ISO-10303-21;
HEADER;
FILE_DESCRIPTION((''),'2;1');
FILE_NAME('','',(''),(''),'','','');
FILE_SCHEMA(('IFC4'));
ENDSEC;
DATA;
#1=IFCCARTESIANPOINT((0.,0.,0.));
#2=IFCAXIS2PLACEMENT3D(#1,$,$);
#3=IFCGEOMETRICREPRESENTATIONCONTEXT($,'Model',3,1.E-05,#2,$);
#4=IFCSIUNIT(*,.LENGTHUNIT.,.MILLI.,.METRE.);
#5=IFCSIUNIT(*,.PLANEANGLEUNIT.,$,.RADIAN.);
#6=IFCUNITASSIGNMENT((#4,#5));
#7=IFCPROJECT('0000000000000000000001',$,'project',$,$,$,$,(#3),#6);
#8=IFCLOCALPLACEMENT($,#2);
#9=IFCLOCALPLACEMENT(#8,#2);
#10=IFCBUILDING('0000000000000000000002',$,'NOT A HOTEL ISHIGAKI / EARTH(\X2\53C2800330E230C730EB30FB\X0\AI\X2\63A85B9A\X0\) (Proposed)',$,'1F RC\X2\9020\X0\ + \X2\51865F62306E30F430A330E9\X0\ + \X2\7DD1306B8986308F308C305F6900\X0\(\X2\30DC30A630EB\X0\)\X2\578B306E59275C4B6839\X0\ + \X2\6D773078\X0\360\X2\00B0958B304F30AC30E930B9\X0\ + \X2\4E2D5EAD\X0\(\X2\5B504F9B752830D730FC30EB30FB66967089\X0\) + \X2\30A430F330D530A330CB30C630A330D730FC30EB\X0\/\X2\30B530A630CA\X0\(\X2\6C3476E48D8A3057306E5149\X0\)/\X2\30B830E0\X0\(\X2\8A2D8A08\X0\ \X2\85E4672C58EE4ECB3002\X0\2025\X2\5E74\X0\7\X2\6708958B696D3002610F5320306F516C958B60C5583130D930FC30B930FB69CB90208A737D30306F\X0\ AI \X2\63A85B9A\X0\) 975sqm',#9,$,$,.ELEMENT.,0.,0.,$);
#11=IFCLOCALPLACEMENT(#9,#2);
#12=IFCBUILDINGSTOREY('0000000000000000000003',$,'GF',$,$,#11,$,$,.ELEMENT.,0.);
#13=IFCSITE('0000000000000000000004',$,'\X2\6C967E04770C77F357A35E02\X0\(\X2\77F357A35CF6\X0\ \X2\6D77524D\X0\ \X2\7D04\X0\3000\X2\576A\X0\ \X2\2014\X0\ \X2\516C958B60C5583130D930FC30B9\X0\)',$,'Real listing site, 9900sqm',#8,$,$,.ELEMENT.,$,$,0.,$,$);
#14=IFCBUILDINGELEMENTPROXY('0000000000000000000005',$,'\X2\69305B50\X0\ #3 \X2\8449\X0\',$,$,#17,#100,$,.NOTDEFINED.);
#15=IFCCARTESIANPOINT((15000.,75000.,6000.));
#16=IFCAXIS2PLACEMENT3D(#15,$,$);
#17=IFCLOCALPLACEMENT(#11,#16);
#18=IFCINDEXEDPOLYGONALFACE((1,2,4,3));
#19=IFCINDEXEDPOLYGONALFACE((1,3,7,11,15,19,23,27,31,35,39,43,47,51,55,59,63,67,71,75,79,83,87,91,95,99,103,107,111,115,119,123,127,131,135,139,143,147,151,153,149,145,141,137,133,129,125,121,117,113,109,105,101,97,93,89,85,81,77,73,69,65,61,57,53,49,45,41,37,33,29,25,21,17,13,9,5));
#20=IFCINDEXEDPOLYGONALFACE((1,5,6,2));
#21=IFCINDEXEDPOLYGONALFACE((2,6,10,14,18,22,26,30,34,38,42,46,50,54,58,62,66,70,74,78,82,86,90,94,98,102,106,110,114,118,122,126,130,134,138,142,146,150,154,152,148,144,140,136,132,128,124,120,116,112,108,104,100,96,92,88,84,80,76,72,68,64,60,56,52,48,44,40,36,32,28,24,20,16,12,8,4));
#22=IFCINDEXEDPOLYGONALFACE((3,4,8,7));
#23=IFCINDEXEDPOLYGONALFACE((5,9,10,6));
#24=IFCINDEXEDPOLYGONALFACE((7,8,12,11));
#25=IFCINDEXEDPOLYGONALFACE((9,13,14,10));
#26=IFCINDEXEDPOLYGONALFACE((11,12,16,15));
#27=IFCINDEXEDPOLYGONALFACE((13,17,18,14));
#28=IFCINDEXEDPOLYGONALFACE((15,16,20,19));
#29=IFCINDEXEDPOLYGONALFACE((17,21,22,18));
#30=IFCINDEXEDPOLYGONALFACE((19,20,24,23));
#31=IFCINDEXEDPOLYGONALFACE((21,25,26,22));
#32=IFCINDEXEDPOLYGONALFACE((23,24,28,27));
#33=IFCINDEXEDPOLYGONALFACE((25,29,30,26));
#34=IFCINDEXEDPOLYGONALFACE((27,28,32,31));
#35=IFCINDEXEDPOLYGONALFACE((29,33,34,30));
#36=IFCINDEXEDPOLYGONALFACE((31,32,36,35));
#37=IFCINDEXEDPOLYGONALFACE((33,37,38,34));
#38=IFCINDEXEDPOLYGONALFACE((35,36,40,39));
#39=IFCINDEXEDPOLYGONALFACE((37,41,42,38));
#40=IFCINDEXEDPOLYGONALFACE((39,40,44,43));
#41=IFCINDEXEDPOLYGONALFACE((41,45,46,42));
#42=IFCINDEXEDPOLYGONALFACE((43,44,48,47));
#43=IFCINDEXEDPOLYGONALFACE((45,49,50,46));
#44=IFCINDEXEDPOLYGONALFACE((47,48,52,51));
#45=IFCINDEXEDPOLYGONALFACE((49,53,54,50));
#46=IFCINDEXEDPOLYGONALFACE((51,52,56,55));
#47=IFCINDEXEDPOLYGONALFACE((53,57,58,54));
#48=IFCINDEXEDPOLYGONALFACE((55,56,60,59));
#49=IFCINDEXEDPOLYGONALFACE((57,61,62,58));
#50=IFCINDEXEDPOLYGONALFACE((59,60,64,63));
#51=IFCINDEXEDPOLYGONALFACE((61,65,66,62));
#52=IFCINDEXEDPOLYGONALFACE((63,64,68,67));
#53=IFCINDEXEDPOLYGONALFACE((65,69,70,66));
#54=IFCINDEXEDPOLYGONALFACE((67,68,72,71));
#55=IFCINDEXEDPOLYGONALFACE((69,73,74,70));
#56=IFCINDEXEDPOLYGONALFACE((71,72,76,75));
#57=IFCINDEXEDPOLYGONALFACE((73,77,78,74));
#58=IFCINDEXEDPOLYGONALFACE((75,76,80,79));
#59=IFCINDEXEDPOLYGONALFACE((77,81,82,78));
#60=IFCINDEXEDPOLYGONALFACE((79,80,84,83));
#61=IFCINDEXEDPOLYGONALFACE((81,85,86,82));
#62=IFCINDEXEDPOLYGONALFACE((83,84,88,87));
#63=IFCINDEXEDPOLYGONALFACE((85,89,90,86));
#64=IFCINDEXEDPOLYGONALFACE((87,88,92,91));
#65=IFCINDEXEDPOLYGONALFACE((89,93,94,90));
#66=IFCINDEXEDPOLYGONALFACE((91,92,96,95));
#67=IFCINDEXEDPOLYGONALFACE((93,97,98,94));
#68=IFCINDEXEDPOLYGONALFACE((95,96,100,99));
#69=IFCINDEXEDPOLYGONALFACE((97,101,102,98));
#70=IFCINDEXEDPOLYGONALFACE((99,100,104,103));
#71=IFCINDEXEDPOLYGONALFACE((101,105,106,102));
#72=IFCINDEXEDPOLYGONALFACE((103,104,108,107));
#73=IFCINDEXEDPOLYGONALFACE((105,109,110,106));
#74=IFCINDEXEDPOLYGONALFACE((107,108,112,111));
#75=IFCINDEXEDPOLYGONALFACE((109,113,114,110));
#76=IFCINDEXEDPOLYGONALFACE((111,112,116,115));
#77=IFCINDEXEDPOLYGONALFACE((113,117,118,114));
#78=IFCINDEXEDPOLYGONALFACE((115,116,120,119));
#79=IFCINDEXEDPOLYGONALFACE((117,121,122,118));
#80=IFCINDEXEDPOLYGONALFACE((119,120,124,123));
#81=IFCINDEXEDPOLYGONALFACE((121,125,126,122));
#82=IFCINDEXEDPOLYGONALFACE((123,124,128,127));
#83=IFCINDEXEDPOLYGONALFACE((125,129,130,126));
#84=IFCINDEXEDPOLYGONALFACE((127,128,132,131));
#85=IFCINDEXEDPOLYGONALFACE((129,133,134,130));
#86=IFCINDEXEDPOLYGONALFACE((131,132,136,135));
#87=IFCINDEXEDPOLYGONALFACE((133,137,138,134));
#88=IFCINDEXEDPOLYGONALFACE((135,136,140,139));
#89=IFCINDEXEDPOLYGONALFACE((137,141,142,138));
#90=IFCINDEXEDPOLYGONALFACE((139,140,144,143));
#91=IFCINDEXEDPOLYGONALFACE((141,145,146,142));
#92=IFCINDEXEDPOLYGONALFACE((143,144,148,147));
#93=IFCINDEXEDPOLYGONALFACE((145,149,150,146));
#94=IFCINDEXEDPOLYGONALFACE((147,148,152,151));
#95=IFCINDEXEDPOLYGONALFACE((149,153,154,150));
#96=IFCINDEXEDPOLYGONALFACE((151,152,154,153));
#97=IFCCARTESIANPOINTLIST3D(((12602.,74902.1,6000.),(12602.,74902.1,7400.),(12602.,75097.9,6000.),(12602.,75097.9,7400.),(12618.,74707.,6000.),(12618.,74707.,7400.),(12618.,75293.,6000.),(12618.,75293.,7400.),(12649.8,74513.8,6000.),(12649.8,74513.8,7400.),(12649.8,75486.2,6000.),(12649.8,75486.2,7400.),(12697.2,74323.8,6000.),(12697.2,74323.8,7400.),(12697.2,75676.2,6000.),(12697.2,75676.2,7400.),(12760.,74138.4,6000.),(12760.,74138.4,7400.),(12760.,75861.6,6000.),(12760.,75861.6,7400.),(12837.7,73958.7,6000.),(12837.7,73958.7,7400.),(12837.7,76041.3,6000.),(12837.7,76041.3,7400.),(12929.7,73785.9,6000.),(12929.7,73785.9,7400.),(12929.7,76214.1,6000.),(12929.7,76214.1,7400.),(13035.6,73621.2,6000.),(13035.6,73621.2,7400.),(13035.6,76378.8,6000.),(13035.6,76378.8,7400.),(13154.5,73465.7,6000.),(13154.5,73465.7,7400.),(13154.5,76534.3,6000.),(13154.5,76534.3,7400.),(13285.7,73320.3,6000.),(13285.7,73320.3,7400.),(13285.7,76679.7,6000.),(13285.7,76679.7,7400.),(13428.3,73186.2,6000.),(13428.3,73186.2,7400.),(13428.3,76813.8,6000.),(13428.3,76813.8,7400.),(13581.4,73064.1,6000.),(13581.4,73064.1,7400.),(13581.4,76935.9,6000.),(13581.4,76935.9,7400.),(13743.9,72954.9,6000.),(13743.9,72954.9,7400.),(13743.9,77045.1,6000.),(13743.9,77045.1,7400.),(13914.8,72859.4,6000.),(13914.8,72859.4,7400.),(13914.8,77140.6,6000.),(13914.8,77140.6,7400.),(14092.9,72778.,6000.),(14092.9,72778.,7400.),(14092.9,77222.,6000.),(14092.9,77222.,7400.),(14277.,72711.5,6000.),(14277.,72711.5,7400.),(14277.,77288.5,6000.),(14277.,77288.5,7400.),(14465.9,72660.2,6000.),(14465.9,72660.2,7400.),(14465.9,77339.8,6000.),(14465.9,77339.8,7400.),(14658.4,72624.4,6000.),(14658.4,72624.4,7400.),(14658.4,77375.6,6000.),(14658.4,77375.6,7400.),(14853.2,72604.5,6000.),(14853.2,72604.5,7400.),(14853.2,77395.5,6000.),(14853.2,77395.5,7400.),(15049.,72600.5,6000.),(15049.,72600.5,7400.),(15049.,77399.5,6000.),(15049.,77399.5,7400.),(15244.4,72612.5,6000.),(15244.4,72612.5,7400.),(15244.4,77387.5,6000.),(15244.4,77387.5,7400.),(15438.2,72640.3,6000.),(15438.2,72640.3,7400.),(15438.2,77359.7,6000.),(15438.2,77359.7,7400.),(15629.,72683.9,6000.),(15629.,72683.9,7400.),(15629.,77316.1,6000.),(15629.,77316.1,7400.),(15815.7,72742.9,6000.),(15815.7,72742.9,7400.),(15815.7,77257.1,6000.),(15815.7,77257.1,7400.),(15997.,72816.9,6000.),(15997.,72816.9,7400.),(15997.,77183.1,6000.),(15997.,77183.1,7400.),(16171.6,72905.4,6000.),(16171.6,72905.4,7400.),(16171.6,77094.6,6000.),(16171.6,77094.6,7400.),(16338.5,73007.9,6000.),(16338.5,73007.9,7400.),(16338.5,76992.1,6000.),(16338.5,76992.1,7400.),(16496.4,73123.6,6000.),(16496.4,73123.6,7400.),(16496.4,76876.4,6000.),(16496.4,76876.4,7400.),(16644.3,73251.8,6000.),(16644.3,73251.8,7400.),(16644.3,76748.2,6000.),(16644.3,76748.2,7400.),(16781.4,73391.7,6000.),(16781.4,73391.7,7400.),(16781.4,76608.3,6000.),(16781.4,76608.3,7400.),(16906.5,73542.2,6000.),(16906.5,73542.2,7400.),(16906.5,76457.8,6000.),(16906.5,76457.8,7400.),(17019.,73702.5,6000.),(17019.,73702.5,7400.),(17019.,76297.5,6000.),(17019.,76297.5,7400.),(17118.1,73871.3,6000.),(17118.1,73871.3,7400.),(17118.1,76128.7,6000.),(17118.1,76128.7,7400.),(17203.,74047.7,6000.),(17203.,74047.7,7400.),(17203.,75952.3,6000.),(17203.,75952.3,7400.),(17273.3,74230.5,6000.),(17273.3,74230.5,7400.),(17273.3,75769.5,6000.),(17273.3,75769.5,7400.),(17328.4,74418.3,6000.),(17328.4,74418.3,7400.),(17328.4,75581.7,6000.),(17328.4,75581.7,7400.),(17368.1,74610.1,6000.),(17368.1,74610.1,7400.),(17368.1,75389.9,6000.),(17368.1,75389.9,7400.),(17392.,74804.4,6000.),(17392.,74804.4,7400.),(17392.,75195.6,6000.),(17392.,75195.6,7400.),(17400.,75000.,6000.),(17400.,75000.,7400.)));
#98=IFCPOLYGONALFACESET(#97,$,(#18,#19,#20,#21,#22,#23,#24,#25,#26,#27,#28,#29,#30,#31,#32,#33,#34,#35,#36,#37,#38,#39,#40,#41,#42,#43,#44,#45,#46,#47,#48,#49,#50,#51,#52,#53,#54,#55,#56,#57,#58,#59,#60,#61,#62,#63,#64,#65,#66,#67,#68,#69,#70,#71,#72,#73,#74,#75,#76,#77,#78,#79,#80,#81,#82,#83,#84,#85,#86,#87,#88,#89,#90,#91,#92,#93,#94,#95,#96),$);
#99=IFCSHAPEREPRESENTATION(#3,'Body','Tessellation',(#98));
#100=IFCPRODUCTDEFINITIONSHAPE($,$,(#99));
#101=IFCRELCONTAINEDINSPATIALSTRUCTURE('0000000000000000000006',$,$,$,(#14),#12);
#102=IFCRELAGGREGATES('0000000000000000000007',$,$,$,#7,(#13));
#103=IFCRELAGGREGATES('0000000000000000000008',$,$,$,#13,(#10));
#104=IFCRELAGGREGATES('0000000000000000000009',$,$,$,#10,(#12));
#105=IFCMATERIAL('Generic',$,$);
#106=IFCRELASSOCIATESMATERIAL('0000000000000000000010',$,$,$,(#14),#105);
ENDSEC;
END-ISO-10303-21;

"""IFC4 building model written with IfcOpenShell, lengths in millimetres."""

from ifc_helpers import new_model, si_unit, frame, origin, origin_2d, place, context, project, spatial, circle, extrude, material, element, save


model = new_model("IFC4")

# Units and contexts
model_context = context("Model", 3, precision=1e-05, world=origin())
ifc_project = project(units=[si_unit("LENGTHUNIT", "METRE", prefix="MILLI"), si_unit("PLANEANGLEUNIT", "RADIAN")], contexts=[model_context])

# Site, building, storey
site_placement = place(None, origin())
site = spatial("IfcSite", under=ifc_project, at=site_placement, Name="沖縄県石垣市(石垣島 海前 約3000坪 — 公開情報ベース)", ObjectType="Real listing site, 9900sqm", CompositionType="ELEMENT", RefElevation=0.0)
building_placement = place(site_placement, origin())
building = spatial("IfcBuilding", under=site, at=building_placement, Name="NOT A HOTEL ISHIGAKI / EARTH(参考モデル・AI推定) (Proposed)", ObjectType="1F RC造 + 円形のヴィラ + 緑に覆われた椀(ボウル)型の大屋根 + 海へ360°開くガラス + 中庭(子供用プール・暖炉) + インフィニティプール/サウナ(水盤越しの光)/ジム(設計 藤本壮介。2025年7月開業。意匠は公開情報ベース・構造詳細は AI 推定) 975sqm", CompositionType="ELEMENT", ElevationOfRefHeight=0.0, ElevationOfTerrain=0.0)
storey_placement = place(building_placement, origin())
storey = spatial("IfcBuildingStorey", under=building, at=storey_placement, Name="GF", CompositionType="ELEMENT", Elevation=0.0)

# Shared definitions
ifc_material_1 = material(Name="Generic")

# Building element proxy
proxy_1_placement = place(storey_placement, frame((15000.0, 75000.0, 6000.0)))
element("IfcBuildingElementProxy", 1, at=proxy_1_placement, inside=storey, material=ifc_material_1, Name="椰子 #3 葉", PredefinedType="NOTDEFINED", context=model_context, shape_type="SweptSolid", body=[
    extrude(circle(Radius=2400.0, at=origin_2d()), frame((15000.0, 75000.0, 6000.0)), (0.0, 0.0, 1.0), 1400.0),
])

save(model, "model.ifc")
